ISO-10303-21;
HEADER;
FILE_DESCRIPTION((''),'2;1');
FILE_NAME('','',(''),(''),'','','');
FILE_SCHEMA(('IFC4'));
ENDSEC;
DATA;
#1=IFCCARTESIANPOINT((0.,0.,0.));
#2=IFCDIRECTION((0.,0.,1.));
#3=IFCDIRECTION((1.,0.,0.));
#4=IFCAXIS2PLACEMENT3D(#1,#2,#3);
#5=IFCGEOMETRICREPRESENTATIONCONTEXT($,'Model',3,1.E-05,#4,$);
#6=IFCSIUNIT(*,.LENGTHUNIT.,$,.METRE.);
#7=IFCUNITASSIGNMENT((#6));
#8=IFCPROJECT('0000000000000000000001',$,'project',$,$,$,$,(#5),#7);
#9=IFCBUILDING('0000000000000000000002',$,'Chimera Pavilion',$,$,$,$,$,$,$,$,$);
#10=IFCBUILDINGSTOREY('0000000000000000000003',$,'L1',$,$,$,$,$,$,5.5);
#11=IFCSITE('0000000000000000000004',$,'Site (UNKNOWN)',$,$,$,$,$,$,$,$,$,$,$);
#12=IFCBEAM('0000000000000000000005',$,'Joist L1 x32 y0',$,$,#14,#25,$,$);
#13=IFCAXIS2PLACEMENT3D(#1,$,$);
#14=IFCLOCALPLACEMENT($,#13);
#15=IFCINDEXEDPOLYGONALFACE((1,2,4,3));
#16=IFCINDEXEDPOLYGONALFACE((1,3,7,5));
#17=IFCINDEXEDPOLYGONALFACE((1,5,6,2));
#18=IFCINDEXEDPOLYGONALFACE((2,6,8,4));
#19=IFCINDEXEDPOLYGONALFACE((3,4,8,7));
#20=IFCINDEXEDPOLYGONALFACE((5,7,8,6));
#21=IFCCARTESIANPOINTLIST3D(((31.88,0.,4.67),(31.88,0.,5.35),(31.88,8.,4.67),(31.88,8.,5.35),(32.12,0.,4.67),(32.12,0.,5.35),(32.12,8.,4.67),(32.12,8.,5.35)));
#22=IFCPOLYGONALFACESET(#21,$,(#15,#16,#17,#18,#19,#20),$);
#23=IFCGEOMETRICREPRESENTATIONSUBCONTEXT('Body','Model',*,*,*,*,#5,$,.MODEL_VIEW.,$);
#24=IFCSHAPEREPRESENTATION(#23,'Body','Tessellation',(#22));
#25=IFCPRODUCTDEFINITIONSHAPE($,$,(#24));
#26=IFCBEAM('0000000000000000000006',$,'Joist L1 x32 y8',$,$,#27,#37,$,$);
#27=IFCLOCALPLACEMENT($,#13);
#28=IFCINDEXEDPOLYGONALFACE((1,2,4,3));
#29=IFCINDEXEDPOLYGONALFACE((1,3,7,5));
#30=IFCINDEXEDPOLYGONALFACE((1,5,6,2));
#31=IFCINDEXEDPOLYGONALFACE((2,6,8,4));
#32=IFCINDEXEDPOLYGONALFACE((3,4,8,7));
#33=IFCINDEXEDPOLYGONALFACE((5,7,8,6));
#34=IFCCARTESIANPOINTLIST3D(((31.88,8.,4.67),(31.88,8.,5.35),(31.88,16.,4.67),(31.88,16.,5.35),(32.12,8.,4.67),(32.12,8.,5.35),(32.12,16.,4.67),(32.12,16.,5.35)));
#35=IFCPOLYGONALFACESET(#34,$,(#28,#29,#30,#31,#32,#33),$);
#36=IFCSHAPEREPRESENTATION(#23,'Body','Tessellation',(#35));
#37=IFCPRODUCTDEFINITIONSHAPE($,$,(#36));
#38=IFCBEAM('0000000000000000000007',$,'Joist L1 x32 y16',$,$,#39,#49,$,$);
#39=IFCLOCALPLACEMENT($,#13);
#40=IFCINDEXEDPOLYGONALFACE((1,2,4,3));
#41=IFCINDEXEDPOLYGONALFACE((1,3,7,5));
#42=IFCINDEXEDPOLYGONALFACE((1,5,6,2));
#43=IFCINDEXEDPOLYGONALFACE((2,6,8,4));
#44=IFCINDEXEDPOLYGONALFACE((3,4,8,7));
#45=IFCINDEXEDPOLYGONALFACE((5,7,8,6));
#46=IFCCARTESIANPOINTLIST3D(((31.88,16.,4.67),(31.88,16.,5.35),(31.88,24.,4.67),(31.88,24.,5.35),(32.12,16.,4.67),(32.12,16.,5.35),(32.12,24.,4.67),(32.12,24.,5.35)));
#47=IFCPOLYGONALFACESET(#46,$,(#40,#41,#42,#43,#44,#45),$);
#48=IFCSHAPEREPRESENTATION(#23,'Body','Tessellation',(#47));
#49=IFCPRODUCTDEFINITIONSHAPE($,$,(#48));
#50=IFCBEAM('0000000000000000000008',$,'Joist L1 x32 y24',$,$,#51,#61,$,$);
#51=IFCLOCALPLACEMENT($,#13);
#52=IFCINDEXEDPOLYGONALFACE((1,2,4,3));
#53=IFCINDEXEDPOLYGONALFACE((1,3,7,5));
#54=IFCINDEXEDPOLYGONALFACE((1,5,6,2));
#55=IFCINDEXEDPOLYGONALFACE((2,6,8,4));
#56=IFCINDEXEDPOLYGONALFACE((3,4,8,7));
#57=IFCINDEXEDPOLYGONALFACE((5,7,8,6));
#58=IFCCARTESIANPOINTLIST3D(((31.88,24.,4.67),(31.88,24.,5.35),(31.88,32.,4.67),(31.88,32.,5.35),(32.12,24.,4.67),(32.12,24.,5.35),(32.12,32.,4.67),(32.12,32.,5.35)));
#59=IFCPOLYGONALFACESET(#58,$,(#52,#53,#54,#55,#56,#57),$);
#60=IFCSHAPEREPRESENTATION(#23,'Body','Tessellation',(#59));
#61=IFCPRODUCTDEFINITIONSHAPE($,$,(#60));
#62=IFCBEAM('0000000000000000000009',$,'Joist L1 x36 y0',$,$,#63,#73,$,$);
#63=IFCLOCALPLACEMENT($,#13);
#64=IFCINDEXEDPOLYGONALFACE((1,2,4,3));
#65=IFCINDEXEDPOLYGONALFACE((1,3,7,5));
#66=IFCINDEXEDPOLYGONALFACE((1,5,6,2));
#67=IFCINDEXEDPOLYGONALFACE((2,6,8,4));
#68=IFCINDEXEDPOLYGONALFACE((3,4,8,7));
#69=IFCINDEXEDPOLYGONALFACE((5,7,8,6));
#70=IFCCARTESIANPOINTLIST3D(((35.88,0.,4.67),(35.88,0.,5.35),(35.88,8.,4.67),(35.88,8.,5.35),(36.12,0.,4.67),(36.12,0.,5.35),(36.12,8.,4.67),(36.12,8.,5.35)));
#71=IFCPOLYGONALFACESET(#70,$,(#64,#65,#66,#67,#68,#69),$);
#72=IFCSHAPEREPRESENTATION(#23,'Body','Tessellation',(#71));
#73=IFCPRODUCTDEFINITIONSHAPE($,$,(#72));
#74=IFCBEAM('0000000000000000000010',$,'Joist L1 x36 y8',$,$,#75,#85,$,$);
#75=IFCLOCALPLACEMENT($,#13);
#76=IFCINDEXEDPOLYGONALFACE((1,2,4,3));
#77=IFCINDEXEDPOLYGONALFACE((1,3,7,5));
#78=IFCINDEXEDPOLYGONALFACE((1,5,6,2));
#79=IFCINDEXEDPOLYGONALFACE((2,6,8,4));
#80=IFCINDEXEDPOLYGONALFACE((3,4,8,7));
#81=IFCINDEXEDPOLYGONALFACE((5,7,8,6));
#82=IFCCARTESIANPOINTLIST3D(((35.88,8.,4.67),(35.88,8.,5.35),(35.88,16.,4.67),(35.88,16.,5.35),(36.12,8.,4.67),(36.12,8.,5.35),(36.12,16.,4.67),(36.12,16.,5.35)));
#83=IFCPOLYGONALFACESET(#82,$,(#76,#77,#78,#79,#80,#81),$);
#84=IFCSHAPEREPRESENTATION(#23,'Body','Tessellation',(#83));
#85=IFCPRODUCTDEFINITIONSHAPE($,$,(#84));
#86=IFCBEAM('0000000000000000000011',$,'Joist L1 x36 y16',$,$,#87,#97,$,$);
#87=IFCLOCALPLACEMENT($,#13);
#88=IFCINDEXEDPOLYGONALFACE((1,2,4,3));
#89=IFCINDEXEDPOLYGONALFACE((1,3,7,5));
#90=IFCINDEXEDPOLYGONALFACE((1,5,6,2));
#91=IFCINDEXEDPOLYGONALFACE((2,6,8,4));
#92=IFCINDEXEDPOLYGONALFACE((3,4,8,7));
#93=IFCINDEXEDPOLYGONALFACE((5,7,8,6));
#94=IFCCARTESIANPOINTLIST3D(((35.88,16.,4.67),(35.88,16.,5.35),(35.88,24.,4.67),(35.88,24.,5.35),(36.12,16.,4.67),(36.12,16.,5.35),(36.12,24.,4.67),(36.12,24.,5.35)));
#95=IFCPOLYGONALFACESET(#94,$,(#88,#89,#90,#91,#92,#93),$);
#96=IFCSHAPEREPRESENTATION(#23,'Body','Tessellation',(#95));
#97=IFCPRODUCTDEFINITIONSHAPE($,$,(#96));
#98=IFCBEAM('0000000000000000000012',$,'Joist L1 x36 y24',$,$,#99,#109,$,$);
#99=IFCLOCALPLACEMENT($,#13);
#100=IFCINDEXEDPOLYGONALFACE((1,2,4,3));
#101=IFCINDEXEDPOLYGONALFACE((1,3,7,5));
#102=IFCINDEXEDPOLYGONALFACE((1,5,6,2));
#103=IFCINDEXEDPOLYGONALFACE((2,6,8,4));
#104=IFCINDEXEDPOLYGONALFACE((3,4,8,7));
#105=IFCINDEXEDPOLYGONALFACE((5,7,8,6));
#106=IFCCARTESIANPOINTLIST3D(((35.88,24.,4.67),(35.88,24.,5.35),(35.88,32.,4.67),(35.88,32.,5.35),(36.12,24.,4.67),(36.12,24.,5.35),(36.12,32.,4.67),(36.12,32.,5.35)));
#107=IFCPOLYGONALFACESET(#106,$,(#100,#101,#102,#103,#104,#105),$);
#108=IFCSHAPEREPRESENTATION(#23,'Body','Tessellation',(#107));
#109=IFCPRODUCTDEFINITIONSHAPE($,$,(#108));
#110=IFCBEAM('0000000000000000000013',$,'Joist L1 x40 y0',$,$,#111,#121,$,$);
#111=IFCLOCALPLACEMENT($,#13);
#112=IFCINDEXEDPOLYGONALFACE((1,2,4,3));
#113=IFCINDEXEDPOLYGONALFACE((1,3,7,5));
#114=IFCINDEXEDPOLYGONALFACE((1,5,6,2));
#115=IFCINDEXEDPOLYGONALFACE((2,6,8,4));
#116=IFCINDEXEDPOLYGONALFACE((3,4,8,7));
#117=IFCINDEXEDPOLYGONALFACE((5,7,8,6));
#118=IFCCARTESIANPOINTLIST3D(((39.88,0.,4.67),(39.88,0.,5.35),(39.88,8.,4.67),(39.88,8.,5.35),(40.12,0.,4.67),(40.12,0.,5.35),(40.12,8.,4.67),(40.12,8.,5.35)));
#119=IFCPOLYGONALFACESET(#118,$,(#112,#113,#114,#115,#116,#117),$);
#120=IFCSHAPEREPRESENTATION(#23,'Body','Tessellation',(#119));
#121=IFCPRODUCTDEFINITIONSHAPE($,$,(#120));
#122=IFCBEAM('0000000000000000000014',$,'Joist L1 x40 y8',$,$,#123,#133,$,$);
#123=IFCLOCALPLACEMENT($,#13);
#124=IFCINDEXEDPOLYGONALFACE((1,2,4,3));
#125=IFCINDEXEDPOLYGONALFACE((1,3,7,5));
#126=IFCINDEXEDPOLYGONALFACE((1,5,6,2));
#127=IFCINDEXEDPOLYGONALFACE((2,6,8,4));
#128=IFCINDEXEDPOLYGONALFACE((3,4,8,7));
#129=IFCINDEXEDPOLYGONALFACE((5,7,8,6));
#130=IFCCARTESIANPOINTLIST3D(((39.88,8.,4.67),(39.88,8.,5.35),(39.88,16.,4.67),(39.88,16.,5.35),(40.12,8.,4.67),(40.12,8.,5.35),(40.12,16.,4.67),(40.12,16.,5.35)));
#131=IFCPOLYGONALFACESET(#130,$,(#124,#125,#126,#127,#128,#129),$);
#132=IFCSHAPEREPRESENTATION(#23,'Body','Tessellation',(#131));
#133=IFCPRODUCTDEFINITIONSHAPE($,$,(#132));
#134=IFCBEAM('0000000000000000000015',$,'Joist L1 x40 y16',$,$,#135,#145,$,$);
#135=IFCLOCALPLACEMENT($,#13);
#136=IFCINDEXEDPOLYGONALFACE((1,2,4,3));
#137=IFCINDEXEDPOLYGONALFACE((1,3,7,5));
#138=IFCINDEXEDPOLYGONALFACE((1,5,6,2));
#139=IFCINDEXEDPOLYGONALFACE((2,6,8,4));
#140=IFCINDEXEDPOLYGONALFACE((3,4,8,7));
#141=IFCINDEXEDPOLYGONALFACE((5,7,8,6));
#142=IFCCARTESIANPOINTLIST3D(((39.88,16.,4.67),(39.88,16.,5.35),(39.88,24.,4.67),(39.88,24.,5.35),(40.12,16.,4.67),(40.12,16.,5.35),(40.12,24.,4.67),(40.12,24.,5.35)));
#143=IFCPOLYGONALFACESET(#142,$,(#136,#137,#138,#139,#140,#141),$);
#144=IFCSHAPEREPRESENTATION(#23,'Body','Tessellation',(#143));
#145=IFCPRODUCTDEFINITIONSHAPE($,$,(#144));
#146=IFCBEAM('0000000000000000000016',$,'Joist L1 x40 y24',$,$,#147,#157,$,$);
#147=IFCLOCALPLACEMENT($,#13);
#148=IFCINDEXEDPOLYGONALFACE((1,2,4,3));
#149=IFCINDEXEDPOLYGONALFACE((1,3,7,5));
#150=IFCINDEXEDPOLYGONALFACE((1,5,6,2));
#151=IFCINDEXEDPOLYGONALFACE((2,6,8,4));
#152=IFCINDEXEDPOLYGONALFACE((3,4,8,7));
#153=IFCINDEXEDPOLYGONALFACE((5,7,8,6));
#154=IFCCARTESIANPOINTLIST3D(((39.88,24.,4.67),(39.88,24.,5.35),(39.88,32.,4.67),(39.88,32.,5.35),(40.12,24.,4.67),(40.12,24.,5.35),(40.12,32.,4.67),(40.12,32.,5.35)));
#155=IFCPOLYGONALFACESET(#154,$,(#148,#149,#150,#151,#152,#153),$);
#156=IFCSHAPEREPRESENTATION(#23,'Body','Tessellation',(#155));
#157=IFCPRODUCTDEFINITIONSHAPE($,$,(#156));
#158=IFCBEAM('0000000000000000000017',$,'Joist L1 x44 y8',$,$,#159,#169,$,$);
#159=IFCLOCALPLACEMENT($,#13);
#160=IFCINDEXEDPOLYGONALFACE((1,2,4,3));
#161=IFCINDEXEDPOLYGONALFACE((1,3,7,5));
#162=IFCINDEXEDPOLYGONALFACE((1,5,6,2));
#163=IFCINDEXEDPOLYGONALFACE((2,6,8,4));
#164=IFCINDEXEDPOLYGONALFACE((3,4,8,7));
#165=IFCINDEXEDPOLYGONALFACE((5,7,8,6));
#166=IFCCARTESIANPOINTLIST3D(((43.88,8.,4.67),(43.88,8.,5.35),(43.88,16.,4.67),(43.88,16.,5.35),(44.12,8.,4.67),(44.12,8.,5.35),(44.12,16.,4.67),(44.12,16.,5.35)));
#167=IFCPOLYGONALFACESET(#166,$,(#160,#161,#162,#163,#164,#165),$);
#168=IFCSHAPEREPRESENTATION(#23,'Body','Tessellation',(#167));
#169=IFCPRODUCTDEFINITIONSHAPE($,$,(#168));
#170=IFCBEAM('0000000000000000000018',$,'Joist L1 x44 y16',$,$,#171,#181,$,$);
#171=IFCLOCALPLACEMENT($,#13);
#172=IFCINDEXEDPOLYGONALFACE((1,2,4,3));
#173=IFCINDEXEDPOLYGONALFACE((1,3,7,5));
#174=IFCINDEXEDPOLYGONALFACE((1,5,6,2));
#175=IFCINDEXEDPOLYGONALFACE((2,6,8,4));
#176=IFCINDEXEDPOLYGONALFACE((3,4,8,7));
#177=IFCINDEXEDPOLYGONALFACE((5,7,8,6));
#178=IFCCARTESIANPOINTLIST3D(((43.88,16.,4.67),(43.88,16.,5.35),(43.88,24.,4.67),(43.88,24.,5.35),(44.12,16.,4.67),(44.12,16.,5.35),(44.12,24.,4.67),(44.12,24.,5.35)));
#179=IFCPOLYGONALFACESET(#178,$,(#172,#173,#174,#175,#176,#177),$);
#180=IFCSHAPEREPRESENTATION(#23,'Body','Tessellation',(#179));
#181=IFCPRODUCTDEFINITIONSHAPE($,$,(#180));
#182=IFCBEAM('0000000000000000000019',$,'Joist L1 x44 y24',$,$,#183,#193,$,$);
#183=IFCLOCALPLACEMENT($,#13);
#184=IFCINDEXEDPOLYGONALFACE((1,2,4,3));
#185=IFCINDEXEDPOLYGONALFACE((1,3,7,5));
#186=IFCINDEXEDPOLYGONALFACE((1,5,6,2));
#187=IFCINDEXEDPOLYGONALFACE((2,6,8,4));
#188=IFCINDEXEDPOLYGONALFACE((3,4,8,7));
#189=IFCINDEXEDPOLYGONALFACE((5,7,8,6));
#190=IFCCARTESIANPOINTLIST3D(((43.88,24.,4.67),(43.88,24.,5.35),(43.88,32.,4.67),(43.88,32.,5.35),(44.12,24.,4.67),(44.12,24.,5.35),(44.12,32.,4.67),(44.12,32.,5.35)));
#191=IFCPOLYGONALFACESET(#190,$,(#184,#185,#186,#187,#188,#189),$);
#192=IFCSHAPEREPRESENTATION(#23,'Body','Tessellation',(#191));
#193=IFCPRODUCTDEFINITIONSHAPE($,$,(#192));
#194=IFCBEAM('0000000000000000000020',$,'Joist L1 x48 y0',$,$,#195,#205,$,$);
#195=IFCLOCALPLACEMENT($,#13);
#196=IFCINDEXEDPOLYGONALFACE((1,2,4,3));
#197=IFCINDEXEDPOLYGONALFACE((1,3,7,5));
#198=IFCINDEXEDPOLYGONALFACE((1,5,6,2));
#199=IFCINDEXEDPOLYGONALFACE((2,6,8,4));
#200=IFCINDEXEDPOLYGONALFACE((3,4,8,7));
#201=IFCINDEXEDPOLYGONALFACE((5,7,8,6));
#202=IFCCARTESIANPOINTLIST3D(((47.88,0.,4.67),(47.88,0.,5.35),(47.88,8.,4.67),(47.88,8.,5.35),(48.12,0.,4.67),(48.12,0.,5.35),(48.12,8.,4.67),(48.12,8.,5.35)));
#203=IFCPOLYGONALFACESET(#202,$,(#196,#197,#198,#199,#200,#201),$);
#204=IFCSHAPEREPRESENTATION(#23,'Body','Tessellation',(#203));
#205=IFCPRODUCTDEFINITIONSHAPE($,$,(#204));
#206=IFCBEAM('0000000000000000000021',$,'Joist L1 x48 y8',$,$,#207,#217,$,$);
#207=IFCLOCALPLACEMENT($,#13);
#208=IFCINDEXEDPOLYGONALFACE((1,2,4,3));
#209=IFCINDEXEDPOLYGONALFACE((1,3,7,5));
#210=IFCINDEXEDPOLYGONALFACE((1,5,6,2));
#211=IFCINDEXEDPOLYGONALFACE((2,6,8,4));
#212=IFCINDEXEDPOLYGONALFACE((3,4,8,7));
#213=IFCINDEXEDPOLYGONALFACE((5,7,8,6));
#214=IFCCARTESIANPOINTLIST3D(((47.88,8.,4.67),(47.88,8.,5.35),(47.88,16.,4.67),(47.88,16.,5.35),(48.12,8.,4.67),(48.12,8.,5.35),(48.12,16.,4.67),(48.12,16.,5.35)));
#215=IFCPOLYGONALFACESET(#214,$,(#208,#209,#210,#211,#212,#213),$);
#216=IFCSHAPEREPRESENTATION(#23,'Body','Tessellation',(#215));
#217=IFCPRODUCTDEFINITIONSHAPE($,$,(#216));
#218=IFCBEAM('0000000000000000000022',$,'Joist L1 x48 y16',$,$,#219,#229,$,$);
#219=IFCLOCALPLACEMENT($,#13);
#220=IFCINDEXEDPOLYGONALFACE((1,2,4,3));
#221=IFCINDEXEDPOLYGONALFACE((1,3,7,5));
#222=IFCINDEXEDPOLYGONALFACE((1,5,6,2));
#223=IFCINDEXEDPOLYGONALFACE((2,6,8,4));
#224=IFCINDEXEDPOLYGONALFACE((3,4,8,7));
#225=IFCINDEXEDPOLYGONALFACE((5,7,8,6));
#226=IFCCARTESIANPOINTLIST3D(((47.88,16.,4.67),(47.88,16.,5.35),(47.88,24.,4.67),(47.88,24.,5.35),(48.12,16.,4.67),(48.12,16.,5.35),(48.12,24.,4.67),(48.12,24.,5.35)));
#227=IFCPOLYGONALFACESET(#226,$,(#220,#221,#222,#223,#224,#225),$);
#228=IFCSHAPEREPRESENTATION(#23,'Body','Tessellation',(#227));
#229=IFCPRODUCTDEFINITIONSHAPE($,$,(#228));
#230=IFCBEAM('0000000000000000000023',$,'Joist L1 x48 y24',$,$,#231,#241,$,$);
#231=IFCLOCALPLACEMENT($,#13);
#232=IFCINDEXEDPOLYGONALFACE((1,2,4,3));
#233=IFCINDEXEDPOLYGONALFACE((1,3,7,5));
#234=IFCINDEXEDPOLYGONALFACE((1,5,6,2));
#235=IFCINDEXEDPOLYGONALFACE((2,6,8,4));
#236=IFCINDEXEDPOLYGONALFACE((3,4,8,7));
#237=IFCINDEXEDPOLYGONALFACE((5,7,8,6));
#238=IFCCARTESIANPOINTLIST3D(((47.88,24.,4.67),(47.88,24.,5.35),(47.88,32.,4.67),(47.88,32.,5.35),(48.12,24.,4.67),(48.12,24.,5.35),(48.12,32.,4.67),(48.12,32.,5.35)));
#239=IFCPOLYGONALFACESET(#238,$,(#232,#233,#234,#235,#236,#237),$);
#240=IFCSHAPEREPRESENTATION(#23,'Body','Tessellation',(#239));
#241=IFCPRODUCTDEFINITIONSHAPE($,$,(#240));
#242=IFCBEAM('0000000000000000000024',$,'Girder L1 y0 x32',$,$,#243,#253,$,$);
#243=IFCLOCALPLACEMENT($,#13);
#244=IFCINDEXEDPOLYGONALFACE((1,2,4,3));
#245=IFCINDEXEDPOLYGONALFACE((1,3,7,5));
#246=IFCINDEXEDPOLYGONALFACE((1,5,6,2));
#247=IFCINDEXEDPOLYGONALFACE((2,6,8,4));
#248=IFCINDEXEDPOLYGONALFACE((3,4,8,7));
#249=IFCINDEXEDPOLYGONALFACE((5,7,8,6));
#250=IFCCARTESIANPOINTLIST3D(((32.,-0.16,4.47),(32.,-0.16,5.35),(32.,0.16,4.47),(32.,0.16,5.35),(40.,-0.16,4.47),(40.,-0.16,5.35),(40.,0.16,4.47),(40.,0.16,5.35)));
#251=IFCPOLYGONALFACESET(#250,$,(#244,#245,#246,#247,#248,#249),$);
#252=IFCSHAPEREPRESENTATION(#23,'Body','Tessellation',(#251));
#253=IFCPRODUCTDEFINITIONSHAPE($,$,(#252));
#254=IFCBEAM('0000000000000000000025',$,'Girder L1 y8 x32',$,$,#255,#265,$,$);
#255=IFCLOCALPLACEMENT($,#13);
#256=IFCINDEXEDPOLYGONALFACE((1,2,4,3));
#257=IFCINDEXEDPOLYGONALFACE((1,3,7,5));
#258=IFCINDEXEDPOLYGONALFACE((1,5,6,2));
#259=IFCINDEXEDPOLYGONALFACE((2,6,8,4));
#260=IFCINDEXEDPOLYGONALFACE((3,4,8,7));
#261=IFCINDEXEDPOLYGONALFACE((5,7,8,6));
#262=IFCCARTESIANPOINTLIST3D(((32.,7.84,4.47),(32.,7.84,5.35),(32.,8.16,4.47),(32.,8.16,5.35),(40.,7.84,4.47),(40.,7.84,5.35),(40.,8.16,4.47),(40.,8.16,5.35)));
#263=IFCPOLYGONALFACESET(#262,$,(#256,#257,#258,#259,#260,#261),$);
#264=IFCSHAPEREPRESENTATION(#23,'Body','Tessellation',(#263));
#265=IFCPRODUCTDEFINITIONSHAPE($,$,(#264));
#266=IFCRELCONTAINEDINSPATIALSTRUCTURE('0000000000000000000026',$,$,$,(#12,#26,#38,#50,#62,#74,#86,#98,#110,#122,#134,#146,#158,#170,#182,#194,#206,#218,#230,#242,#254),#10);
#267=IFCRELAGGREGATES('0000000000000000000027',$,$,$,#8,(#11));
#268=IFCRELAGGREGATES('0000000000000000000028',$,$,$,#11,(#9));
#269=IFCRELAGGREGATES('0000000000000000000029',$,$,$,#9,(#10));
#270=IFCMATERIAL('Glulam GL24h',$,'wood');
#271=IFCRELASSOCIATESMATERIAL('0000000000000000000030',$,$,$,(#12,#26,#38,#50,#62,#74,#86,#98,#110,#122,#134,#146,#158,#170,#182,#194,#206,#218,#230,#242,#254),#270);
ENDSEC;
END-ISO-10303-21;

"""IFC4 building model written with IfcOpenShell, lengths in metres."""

from ifc_helpers import new_model, si_unit, frame, origin_with_axes, place, context, subcontext, project, spatial, rectangle, extrude, material, element, save


model = new_model("IFC4")

# Units and contexts
model_context = context("Model", 3, precision=1e-05, world=origin_with_axes())
body_context = subcontext(model_context, "Body", "Model", "MODEL_VIEW")
ifc_project = project(units=[si_unit("LENGTHUNIT", "METRE")], contexts=[model_context])

# Site, building, storey
site = spatial("IfcSite", under=ifc_project, Name="Site (UNKNOWN)")
building = spatial("IfcBuilding", under=site, Name="Chimera Pavilion")
storey = spatial("IfcBuildingStorey", under=building, Name="L1", Elevation=5.5)

# Beams
ifc_material_1 = material(Name="Glulam GL24h", Category="wood")
for number, where, z_axis, x_axis, name in (
    (1, (32.0, 0.0, 5.01), (0.0, 1.0, 0.0), (1.0, 0.0, 0.0), "Joist L1 x32 y0"),
    (2, (32.0, 8.0, 5.01), (0.0, 1.0, 0.0), (1.0, 0.0, 0.0), "Joist L1 x32 y8"),
    (3, (32.0, 16.0, 5.01), (0.0, 1.0, 0.0), (1.0, 0.0, 0.0), "Joist L1 x32 y16"),
    (4, (32.0, 24.0, 5.01), (0.0, 1.0, 0.0), (1.0, 0.0, 0.0), "Joist L1 x32 y24"),
    (5, (36.0, 0.0, 5.01), (0.0, 1.0, 0.0), (1.0, 0.0, 0.0), "Joist L1 x36 y0"),
    (6, (36.0, 8.0, 5.01), (0.0, 1.0, 0.0), (1.0, 0.0, 0.0), "Joist L1 x36 y8"),
    (7, (36.0, 16.0, 5.01), (0.0, 1.0, 0.0), (1.0, 0.0, 0.0), "Joist L1 x36 y16"),
    (8, (36.0, 24.0, 5.01), (0.0, 1.0, 0.0), (1.0, 0.0, 0.0), "Joist L1 x36 y24"),
    (9, (40.0, 0.0, 5.01), (0.0, 1.0, 0.0), (1.0, 0.0, 0.0), "Joist L1 x40 y0"),
    (10, (40.0, 8.0, 5.01), (0.0, 1.0, 0.0), (1.0, 0.0, 0.0), "Joist L1 x40 y8"),
    (11, (40.0, 16.0, 5.01), (0.0, 1.0, 0.0), (1.0, 0.0, 0.0), "Joist L1 x40 y16"),
    (12, (40.0, 24.0, 5.01), (0.0, 1.0, 0.0), (1.0, 0.0, 0.0), "Joist L1 x40 y24"),
    (13, (44.0, 8.0, 5.01), (0.0, 1.0, 0.0), (1.0, 0.0, 0.0), "Joist L1 x44 y8"),
    (14, (44.0, 16.0, 5.01), (0.0, 1.0, 0.0), (1.0, 0.0, 0.0), "Joist L1 x44 y16"),
    (15, (44.0, 24.0, 5.01), (0.0, 1.0, 0.0), (1.0, 0.0, 0.0), "Joist L1 x44 y24"),
    (16, (48.0, 0.0, 5.01), (0.0, 1.0, 0.0), (1.0, 0.0, 0.0), "Joist L1 x48 y0"),
    (17, (48.0, 8.0, 5.01), (0.0, 1.0, 0.0), (1.0, 0.0, 0.0), "Joist L1 x48 y8"),
    (18, (48.0, 16.0, 5.01), (0.0, 1.0, 0.0), (1.0, 0.0, 0.0), "Joist L1 x48 y16"),
    (19, (48.0, 24.0, 5.01), (0.0, 1.0, 0.0), (1.0, 0.0, 0.0), "Joist L1 x48 y24"),
):
    element("IfcBeam", number, at=place(None, frame(where, z_axis=z_axis, x_axis=x_axis)), inside=storey, material=ifc_material_1, Name=name, context=body_context, shape_type="SweptSolid", body=[
        extrude(rectangle(XDim=0.24, YDim=0.68), origin_with_axes(), (0.0, 0.0, 1.0), 8.0),
    ])
for number, where, z_axis, x_axis, name in (
    (20, (32.0, 0.0, 4.91), (1.0, 0.0, 0.0), (0.0, -1.0, 0.0), "Girder L1 y0 x32"),
    (21, (32.0, 8.0, 4.91), (1.0, 0.0, 0.0), (0.0, -1.0, 0.0), "Girder L1 y8 x32"),
):
    element("IfcBeam", number, at=place(None, frame(where, z_axis=z_axis, x_axis=x_axis)), inside=storey, material=ifc_material_1, Name=name, context=body_context, shape_type="SweptSolid", body=[
        extrude(rectangle(XDim=0.32, YDim=0.88), origin_with_axes(), (0.0, 0.0, 1.0), 8.0),
    ])

save(model, "model.ifc")
